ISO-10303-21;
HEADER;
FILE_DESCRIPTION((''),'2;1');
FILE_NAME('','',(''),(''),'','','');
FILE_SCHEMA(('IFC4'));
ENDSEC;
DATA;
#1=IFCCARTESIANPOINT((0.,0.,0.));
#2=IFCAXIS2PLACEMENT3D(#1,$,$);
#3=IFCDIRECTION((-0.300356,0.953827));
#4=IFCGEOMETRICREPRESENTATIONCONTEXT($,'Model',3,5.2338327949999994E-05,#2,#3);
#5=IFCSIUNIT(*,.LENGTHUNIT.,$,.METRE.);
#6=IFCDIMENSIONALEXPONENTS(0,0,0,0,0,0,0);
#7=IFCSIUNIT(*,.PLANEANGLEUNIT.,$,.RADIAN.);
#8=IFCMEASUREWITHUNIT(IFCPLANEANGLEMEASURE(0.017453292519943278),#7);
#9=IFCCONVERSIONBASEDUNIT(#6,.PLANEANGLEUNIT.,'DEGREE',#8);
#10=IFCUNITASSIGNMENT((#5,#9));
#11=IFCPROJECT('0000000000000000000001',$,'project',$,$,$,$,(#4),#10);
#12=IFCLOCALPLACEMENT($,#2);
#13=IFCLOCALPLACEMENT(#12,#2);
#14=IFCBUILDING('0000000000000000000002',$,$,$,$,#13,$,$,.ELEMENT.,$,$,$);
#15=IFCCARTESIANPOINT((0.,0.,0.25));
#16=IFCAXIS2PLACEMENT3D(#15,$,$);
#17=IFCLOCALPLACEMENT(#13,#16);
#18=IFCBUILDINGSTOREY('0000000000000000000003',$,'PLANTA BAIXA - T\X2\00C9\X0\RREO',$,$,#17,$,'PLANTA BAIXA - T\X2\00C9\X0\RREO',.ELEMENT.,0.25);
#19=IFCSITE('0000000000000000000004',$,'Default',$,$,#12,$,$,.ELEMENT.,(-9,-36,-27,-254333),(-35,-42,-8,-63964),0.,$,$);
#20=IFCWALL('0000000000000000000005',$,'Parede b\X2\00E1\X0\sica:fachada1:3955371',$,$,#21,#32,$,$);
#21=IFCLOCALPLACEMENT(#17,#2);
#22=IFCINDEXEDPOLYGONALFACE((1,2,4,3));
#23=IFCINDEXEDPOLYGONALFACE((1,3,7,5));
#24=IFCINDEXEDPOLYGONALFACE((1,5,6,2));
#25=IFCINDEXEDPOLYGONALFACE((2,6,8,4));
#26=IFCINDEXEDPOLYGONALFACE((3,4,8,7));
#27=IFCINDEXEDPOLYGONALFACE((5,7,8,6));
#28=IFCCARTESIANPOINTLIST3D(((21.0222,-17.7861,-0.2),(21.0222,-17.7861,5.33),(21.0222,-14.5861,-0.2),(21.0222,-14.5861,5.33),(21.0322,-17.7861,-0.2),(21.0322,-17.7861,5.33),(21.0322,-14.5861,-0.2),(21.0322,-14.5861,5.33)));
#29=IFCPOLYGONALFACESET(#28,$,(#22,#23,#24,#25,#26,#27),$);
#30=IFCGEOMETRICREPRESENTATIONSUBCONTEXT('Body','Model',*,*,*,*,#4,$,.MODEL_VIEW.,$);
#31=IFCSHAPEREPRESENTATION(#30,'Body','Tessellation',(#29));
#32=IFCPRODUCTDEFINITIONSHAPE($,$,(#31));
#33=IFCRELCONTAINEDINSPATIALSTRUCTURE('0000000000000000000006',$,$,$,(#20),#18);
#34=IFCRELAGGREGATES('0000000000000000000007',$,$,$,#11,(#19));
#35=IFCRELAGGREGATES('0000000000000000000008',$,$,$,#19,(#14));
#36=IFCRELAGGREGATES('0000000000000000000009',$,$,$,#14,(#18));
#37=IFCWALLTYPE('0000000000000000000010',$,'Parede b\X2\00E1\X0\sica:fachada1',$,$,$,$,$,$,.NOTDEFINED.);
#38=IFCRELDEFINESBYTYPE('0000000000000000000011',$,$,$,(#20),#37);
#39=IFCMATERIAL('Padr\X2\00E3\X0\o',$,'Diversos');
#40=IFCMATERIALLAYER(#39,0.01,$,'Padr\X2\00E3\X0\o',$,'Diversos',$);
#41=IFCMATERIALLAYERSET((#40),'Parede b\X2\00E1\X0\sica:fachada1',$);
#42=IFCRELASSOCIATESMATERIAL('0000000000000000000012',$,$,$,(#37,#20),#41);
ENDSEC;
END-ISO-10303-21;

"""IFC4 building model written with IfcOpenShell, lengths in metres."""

from ifc_helpers import new_model, entity, si_unit, converted_unit, direction, frame, frame_2d, origin, place, context, subcontext, project, spatial, rectangle, extrude, material, layer, layer_set, layer_usage, type_object, element, save


model = new_model("IFC4")

# Units and contexts
model_context = context("Model", 3, precision=5.2338327949999994e-05, world=origin(), true_north=direction((-0.300356, 0.953827)))
body_context = subcontext(model_context, "Body", "Model", "MODEL_VIEW")
ifc_project = project(units=[si_unit("LENGTHUNIT", "METRE"), converted_unit("PLANEANGLEUNIT", "DEGREE", entity("IfcPlaneAngleMeasure", 0.017453292519943278), si_unit("PLANEANGLEUNIT", "RADIAN"), dimensions=[0, 0, 0, 0, 0, 0, 0])], contexts=[model_context])

# Site, building, storey
site_placement = place(None, origin())
site = spatial("IfcSite", under=ifc_project, at=site_placement, Name="Default", CompositionType="ELEMENT", RefLatitude=(-9, -36, -27, -254333), RefLongitude=(-35, -42, -8, -63964), RefElevation=0.0)
building_placement = place(site_placement, origin())
building = spatial("IfcBuilding", under=site, at=building_placement, CompositionType="ELEMENT")
storey_placement = place(building_placement, frame((0.0, 0.0, 0.25)))
storey = spatial("IfcBuildingStorey", under=building, at=storey_placement, Name="PLANTA BAIXA - TÉRREO", LongName="PLANTA BAIXA - TÉRREO", CompositionType="ELEMENT", Elevation=0.25)

# Shared definitions
ifc_material_1 = material(Name="Padrão", Category="Diversos")

# Wall
ifc_layer_1 = layer(ifc_material_1, 0.01, Name="Padrão", Category="Diversos")
ifc_layer_set_1 = layer_set([ifc_layer_1], Name="Parede básica:fachada1")
ifc_layer_usage_1 = layer_usage(ifc_layer_set_1, "AXIS2", "NEGATIVE", 0.005)
wall_type_1 = type_object("IfcWallType", Name="Parede básica:fachada1", PredefinedType="NOTDEFINED", material=ifc_layer_set_1)
wall_1_placement = place(storey_placement, frame((21.0272, -17.7861, -0.2), z_axis=(0.0, 0.0, 1.0), x_axis=(0.0, 1.0, 0.0)))
element("IfcWall", 1, at=wall_1_placement, inside=storey, type_object=wall_type_1, material=ifc_layer_usage_1, Name="Parede básica:fachada1:3955371", context=body_context, shape_type="SweptSolid", body=[
    extrude(rectangle(XDim=3.2, YDim=0.01, at=frame_2d((1.6, 0.0), x_axis=(-1.0, 0.0))), origin(), (0.0, 0.0, 1.0), 5.53),
])

save(model, "model.ifc")
